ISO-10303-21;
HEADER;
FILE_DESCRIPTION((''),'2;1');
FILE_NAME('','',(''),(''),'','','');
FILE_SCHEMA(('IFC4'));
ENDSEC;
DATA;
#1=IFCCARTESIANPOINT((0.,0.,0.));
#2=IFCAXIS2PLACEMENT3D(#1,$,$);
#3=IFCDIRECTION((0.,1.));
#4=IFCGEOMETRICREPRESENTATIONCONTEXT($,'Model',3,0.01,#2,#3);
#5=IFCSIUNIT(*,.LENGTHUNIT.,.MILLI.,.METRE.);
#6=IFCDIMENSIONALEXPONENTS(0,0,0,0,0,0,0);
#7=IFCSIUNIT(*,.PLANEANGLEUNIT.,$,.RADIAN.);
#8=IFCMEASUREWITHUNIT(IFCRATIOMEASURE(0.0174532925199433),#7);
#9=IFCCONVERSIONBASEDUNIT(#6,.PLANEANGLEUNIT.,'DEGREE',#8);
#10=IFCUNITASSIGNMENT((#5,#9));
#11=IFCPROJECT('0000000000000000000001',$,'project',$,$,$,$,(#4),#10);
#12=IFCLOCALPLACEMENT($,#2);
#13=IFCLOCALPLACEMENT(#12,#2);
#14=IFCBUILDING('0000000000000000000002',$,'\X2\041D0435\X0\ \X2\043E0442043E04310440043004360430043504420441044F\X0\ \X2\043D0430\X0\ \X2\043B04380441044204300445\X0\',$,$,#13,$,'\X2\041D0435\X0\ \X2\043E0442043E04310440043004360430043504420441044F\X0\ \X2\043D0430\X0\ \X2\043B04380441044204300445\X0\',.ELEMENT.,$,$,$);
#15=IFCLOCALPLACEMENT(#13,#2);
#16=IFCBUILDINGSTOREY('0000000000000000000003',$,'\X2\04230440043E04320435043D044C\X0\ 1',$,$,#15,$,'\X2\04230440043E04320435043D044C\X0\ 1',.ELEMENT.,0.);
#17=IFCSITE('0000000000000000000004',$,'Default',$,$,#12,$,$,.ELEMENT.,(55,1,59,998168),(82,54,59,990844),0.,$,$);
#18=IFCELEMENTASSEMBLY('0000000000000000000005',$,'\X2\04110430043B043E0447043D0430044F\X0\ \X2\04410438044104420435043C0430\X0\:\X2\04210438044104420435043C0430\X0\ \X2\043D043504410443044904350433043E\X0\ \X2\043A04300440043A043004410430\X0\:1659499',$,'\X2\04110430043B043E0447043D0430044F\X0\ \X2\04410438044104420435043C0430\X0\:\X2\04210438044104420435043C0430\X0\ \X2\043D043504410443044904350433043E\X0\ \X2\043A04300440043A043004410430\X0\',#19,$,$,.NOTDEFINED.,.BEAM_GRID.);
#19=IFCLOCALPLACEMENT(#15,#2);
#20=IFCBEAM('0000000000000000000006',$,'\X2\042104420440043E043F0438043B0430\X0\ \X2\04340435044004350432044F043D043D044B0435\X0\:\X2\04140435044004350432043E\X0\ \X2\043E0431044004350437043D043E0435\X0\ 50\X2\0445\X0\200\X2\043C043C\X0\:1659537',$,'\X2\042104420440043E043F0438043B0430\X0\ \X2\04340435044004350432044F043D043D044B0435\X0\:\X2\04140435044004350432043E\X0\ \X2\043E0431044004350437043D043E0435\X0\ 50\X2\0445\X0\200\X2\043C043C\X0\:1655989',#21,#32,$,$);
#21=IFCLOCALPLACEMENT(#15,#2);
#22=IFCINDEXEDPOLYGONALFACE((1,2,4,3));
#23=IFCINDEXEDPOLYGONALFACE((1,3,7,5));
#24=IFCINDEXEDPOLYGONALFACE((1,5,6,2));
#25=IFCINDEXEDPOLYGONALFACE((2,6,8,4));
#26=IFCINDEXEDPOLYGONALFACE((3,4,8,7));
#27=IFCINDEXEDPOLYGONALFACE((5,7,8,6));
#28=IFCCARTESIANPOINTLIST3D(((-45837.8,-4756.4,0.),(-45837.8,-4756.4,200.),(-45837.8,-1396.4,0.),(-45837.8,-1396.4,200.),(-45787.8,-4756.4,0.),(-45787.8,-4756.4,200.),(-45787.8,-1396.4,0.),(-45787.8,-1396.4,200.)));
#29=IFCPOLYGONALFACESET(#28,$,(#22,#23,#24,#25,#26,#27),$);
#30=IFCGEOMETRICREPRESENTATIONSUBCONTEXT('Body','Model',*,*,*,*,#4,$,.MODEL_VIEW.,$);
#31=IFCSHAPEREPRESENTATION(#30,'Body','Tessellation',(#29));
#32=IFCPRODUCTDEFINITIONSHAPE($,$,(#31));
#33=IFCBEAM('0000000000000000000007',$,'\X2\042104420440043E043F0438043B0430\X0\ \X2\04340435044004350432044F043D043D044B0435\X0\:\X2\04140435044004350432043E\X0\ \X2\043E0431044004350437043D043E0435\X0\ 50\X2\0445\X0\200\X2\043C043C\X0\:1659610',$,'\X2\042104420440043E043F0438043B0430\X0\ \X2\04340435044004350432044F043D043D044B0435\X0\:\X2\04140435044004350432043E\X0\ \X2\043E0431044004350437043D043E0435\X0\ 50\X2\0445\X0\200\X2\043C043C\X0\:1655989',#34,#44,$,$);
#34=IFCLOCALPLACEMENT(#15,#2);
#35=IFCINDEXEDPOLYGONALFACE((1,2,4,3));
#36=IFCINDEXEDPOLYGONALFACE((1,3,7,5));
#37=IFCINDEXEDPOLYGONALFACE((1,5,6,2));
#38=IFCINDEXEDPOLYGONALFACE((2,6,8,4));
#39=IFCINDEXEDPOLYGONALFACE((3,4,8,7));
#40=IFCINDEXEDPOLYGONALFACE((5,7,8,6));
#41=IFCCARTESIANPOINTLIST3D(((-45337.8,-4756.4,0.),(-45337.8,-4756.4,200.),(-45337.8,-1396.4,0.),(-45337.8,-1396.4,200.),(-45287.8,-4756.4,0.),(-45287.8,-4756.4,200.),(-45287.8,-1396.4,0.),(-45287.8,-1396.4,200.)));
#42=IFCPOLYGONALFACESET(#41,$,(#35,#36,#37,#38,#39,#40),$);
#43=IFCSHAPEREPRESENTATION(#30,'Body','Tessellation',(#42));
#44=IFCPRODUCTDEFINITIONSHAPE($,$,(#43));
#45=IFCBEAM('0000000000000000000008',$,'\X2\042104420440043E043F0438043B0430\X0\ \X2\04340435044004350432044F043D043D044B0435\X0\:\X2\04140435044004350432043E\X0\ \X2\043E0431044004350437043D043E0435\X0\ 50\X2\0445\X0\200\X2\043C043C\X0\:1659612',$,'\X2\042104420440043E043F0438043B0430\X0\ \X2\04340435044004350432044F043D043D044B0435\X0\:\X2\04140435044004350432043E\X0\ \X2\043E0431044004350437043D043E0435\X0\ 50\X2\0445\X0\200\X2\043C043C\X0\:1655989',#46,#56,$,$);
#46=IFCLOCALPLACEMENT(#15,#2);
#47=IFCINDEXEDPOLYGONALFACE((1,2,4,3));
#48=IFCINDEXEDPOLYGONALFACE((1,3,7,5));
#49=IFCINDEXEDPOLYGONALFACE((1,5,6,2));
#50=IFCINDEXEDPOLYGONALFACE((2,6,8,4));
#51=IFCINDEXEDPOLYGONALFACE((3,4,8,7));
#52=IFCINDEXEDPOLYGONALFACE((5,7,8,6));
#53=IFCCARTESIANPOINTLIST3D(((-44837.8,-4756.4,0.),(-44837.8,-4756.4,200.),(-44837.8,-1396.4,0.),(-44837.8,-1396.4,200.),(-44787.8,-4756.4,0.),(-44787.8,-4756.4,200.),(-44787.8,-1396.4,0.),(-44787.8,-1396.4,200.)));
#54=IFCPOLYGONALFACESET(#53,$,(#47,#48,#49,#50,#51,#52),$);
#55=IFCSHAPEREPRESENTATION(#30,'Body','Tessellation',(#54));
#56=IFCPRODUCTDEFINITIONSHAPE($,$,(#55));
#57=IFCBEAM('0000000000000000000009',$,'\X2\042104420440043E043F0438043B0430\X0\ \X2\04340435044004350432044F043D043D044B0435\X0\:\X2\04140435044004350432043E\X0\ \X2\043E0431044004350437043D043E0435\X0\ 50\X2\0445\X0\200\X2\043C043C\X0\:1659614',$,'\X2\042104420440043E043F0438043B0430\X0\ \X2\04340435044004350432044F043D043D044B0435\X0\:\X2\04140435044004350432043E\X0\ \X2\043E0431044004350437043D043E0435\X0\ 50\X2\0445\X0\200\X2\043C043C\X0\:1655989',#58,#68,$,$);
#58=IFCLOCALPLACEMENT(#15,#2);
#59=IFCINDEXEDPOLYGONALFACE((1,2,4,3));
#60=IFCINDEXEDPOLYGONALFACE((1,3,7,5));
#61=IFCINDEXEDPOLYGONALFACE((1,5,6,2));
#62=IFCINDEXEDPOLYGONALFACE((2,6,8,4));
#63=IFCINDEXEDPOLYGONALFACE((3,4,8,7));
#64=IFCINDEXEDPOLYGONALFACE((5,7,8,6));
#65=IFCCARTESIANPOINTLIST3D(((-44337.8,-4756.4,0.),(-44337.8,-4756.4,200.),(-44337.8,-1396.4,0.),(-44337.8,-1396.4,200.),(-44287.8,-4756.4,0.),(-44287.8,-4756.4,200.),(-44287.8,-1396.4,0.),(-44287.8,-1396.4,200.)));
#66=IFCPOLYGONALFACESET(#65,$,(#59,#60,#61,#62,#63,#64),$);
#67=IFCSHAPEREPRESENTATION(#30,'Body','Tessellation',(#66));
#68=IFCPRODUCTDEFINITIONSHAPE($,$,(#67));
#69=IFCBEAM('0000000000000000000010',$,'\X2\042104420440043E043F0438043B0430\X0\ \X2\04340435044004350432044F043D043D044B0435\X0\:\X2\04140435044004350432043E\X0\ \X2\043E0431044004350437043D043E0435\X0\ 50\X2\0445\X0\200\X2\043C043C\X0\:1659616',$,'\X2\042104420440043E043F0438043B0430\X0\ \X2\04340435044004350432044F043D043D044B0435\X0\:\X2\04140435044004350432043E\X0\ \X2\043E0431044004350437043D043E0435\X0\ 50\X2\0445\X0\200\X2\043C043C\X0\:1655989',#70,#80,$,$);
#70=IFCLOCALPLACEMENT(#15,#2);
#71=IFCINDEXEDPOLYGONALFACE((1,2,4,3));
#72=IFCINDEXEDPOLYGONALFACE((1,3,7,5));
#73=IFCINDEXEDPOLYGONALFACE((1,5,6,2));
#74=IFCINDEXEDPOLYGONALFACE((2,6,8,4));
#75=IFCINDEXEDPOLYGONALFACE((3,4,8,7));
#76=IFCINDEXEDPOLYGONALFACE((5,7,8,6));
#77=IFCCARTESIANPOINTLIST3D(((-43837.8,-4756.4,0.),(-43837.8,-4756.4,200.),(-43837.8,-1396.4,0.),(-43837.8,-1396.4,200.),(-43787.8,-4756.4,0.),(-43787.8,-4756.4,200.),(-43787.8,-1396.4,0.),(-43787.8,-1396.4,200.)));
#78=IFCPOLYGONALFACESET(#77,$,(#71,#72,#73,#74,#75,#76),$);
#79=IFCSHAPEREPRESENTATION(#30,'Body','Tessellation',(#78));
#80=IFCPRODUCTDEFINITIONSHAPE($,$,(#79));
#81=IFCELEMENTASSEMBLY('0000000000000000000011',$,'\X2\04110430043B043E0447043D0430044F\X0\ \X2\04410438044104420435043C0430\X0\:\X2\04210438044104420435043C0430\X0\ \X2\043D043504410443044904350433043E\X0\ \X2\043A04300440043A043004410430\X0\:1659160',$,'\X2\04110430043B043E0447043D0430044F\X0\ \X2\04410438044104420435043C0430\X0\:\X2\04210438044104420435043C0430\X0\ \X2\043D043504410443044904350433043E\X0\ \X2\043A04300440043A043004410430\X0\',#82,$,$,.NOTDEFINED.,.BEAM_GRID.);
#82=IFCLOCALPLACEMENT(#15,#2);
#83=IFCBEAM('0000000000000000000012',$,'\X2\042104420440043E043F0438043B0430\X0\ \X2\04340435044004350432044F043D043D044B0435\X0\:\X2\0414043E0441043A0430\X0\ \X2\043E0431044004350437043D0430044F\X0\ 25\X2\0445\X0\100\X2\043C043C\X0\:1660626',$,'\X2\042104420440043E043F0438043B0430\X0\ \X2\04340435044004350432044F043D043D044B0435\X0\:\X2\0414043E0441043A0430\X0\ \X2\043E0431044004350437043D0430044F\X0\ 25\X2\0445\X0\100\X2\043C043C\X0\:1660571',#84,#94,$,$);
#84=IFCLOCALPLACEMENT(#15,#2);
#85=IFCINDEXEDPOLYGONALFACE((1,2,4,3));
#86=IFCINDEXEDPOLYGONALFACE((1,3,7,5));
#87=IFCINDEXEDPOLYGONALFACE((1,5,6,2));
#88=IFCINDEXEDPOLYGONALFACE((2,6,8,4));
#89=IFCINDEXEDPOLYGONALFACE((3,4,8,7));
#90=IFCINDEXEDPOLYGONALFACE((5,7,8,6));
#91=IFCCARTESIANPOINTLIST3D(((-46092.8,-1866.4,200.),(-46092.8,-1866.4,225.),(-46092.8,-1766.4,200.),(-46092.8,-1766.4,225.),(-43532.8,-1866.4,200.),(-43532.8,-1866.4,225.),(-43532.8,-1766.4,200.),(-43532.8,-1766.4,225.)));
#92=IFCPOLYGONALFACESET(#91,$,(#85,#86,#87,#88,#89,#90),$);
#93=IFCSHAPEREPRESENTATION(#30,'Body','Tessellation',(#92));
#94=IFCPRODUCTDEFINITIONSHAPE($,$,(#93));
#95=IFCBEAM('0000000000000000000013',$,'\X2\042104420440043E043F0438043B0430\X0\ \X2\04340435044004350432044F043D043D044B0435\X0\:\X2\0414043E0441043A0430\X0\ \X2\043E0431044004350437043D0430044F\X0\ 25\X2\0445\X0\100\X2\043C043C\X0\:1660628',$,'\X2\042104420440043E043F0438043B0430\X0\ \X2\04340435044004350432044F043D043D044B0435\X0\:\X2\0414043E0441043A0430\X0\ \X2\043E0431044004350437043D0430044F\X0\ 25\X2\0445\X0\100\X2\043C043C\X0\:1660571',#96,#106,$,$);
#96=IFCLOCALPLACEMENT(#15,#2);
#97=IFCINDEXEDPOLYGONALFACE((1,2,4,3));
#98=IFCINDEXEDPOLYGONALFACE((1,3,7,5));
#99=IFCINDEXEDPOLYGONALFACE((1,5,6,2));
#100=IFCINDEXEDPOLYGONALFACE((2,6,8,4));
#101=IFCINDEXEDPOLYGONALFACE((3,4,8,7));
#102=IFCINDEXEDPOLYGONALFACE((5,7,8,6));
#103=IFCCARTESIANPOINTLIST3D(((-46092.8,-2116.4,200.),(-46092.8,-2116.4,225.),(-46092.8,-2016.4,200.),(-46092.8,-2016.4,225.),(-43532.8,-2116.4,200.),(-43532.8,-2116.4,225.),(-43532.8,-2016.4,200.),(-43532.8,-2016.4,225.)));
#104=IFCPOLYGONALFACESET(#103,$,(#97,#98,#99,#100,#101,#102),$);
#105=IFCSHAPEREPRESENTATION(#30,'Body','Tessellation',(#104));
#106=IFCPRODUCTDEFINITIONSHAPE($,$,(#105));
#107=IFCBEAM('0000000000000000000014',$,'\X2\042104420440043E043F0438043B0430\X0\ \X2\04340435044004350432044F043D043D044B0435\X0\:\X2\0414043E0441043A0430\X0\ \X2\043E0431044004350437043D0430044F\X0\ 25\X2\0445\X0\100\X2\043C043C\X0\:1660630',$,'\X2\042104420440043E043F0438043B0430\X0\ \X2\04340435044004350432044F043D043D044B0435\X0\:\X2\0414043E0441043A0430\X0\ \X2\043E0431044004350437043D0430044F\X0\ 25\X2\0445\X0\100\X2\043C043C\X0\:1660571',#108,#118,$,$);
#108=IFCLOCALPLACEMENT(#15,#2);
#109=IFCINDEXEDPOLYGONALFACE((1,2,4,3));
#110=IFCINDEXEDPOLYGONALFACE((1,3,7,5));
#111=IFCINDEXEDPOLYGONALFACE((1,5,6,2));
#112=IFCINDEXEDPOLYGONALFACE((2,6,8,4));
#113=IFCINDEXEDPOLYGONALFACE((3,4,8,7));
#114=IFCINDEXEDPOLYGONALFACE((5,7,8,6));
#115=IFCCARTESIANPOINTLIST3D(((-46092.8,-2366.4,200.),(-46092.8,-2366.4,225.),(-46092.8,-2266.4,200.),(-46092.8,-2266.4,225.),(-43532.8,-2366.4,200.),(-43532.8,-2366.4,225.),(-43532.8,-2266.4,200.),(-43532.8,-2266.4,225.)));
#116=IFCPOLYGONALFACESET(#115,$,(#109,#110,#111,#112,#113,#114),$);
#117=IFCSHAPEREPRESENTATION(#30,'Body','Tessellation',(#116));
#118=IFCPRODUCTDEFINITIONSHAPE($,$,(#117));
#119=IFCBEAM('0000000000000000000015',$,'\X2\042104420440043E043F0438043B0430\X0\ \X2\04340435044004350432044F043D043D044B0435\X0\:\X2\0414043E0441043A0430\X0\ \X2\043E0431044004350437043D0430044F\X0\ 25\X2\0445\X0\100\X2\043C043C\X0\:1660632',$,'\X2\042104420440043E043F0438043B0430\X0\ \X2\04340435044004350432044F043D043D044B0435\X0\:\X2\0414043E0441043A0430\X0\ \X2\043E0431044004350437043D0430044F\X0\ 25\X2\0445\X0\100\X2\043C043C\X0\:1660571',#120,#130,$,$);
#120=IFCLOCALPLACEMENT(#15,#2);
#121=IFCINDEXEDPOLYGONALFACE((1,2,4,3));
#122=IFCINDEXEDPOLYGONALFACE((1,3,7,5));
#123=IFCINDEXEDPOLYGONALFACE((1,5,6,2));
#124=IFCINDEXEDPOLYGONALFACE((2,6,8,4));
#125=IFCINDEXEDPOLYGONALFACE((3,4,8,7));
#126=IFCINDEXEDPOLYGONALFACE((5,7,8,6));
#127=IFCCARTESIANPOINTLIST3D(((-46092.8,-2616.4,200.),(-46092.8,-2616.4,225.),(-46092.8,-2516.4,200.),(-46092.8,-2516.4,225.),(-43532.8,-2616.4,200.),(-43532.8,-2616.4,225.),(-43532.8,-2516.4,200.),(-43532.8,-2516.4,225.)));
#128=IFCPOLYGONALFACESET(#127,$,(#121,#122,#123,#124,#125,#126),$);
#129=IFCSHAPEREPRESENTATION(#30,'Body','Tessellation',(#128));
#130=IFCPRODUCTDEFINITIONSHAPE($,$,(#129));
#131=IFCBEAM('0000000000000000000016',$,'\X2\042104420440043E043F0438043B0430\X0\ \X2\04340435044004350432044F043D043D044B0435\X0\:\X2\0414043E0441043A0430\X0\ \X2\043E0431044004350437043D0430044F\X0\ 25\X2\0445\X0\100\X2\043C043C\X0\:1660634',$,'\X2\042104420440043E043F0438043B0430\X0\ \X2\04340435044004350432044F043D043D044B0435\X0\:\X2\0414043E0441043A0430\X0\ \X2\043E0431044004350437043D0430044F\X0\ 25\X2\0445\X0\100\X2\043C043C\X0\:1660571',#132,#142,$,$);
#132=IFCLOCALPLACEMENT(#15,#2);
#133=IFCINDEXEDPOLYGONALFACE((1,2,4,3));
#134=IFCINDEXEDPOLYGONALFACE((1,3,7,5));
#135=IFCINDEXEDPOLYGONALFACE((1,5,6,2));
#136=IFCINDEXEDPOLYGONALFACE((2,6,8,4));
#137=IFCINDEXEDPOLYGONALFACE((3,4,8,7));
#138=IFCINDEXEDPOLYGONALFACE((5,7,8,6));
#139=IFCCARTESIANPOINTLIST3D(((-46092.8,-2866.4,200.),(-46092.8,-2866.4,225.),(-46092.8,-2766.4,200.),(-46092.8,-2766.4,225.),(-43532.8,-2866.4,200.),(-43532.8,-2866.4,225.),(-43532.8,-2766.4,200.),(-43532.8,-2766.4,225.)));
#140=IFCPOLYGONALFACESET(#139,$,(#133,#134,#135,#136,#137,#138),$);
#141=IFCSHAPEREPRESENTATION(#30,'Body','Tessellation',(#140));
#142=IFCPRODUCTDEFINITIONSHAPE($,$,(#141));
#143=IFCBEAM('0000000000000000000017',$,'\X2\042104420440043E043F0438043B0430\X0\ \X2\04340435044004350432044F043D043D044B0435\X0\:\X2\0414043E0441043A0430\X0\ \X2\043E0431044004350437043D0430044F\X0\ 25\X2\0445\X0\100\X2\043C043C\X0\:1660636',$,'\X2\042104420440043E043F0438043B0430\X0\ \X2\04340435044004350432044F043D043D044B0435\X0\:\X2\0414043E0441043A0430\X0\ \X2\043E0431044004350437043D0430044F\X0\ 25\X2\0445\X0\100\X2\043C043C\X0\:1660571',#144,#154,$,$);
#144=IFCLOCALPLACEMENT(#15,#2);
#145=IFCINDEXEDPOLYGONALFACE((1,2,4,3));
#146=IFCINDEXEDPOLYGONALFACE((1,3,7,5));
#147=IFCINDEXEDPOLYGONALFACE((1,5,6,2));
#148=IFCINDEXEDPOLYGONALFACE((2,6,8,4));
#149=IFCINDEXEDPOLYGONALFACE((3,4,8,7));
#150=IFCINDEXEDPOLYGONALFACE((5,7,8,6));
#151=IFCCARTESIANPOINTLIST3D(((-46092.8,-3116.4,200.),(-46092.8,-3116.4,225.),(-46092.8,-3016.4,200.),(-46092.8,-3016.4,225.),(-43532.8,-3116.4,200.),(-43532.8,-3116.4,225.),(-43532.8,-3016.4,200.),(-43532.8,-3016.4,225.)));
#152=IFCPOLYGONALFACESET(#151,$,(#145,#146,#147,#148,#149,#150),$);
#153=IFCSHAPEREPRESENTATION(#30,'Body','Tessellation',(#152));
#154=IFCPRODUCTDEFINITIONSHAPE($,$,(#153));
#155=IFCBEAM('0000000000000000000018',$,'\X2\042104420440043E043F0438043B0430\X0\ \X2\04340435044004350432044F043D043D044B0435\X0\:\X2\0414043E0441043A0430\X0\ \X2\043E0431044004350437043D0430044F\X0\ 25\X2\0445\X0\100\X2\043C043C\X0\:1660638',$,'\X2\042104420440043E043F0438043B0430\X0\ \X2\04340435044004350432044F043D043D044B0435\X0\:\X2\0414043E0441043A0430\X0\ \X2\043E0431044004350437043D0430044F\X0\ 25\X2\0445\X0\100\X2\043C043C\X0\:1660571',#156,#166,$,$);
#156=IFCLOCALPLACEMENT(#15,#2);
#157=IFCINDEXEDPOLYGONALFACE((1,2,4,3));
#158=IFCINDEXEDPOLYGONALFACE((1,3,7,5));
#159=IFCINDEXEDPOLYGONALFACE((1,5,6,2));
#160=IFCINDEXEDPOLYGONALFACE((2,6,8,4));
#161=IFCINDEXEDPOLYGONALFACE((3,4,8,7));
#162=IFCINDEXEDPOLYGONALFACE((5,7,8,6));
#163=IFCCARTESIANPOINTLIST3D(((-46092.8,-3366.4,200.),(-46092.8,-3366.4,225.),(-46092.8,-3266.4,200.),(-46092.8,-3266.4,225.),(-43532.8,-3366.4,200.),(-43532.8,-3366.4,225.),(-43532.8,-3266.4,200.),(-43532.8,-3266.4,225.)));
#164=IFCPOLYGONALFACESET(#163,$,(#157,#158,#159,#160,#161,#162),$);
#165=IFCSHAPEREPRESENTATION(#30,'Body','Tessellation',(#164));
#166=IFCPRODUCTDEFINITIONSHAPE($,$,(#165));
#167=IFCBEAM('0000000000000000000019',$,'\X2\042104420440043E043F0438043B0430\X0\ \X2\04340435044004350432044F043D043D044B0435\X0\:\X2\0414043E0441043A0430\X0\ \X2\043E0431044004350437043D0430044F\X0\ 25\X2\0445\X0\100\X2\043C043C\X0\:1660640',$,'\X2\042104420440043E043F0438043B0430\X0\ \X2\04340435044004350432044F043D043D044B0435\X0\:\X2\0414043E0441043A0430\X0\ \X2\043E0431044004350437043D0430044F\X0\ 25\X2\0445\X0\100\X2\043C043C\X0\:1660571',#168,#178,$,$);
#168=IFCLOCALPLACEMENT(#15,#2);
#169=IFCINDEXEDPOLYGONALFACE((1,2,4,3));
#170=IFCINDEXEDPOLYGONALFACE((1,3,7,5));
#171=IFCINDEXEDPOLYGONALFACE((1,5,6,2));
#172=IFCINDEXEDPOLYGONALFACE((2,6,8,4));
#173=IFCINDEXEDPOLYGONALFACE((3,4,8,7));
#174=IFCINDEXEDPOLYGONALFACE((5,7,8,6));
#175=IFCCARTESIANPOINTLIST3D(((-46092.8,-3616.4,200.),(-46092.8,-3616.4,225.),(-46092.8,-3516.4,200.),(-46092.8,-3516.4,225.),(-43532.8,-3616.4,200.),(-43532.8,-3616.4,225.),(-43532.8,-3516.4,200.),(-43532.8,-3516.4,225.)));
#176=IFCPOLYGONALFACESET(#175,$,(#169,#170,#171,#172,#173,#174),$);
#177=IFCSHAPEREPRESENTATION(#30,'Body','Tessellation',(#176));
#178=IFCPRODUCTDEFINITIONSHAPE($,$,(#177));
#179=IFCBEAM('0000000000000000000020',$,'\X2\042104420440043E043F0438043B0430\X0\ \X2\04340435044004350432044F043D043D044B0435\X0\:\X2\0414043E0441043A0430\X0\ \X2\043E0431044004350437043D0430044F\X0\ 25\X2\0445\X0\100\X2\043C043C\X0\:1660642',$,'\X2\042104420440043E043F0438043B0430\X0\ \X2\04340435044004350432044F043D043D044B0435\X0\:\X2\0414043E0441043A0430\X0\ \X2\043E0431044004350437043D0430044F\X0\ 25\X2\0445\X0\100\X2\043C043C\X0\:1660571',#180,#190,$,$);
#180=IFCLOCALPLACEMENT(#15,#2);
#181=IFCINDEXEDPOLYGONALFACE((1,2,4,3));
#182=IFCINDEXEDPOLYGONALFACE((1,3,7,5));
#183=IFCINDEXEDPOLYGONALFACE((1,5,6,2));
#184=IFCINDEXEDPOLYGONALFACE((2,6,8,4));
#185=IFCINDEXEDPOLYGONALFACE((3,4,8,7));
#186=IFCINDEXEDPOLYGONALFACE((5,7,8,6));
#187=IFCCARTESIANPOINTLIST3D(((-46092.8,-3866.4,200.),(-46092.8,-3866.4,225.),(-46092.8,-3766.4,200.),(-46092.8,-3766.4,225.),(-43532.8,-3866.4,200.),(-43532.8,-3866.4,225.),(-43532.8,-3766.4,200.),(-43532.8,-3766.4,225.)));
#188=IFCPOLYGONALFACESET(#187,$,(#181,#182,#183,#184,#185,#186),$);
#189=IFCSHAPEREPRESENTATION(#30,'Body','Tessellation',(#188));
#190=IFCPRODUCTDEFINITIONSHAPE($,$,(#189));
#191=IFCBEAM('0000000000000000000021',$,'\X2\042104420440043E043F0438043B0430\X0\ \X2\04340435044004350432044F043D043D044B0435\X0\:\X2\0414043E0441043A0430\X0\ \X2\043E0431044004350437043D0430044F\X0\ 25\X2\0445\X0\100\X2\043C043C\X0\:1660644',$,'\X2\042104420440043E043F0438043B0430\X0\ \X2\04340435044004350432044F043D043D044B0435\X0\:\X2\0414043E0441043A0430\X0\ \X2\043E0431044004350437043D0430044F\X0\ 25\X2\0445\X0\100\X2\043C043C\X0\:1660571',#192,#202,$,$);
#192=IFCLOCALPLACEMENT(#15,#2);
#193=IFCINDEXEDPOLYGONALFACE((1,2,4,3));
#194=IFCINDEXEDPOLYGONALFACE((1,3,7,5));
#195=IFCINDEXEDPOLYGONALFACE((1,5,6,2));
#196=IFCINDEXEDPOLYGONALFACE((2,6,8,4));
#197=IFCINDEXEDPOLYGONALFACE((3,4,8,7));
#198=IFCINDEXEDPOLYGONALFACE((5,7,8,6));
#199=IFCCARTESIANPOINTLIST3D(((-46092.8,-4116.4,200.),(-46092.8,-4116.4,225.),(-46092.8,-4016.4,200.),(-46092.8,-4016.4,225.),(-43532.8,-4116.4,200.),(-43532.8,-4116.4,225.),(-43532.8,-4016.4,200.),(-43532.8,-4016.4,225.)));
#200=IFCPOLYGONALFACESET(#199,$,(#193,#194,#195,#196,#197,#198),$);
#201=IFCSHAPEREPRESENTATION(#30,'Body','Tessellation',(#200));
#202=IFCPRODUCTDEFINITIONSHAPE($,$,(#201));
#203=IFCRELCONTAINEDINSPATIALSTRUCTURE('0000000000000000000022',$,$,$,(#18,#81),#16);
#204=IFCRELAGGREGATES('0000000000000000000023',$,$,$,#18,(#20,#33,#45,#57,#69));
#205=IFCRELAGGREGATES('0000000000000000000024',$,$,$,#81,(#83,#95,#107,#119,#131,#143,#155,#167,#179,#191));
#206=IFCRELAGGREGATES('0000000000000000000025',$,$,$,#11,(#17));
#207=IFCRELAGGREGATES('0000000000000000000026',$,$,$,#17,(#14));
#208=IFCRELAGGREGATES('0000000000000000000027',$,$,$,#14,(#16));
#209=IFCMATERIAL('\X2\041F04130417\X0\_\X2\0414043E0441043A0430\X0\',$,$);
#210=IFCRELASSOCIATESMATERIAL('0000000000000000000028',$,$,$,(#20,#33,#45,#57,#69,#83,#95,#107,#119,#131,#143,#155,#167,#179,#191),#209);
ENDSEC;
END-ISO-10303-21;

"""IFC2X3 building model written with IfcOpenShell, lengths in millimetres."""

from ifc_helpers import new_model, entity, si_unit, converted_unit, direction, frame, frame_2d, origin, origin_2d_with_axis, place, context, subcontext, project, spatial, rectangle, extrude, material, element, aggregate, save


model = new_model("IFC2X3")

# Units and contexts
model_context = context("Model", 3, precision=0.01, world=origin(), true_north=direction((0.0, 1.0)))
body_context = subcontext(model_context, "Body", "Model", "MODEL_VIEW")
ifc_project = project(units=[si_unit("LENGTHUNIT", "METRE", prefix="MILLI"), converted_unit("PLANEANGLEUNIT", "DEGREE", entity("IfcRatioMeasure", 0.0174532925199433), si_unit("PLANEANGLEUNIT", "RADIAN"), dimensions=[0, 0, 0, 0, 0, 0, 0])], contexts=[model_context])

# Site, building, storey
site_placement = place(None, origin())
site = spatial("IfcSite", under=ifc_project, at=site_placement, Name="Default", CompositionType="ELEMENT", RefLatitude=(55, 1, 59, 998168), RefLongitude=(82, 54, 59, 990844), RefElevation=0.0)
building_placement = place(site_placement, origin())
building = spatial("IfcBuilding", under=site, at=building_placement, Name="Не отображается на листах", LongName="Не отображается на листах", CompositionType="ELEMENT")
storey_placement = place(building_placement, frame((0.0, 0.0, 0.0)))
storey = spatial("IfcBuildingStorey", under=building, at=storey_placement, Name="Уровень 1", LongName="Уровень 1", CompositionType="ELEMENT", Elevation=0.0)

# Element assemblies, beams
assembly_1_placement = place(storey_placement, origin())
assembly_1 = element("IfcElementAssembly", 1, at=assembly_1_placement, inside=storey, Name="Балочная система:Система несущего каркаса:1659499", ObjectType="Балочная система:Система несущего каркаса", AssemblyPlace="NOTDEFINED", PredefinedType="BEAM_GRID")
ifc_material_1 = material(Name="ПГЗ_Доска")
beam_1_placement = place(assembly_1_placement, frame((-45812.8, -4756.4, 0.0), z_axis=(0.0, 0.0, 1.0), x_axis=(0.0, 1.0, 0.0)))
beam_1 = element("IfcBeam", 2, at=beam_1_placement, material=ifc_material_1, Name="Стропила деревянные:Дерево обрезное 50х200мм:1659537", ObjectType="Стропила деревянные:Дерево обрезное 50х200мм:1655989", context=body_context, shape_type="SweptSolid", body=[
    extrude(rectangle(XDim=200.0, YDim=50.0, at=frame_2d((0.0, 0.0), x_axis=(1.0, 0.0))), frame((0.0, 0.0, 100.0), z_axis=(1.0, 0.0, 0.0), x_axis=(0.0, 0.0, -1.0)), (0.0, 0.0, 1.0), 3360.0),
])
beam_2_placement = place(assembly_1_placement, frame((-45312.8, -4756.4, 0.0), z_axis=(0.0, 0.0, 1.0), x_axis=(0.0, 1.0, 0.0)))
beam_2 = element("IfcBeam", 3, at=beam_2_placement, material=ifc_material_1, Name="Стропила деревянные:Дерево обрезное 50х200мм:1659610", ObjectType="Стропила деревянные:Дерево обрезное 50х200мм:1655989", context=body_context, shape_type="SweptSolid", body=[
    extrude(rectangle(XDim=200.0, YDim=50.0, at=frame_2d((0.0, 0.0), x_axis=(1.0, 0.0))), frame((0.0, 0.0, 100.0), z_axis=(1.0, 0.0, 0.0), x_axis=(0.0, 0.0, -1.0)), (0.0, 0.0, 1.0), 3360.0),
])
beam_3_placement = place(assembly_1_placement, frame((-44812.8, -4756.4, 0.0), z_axis=(0.0, 0.0, 1.0), x_axis=(0.0, 1.0, 0.0)))
beam_3 = element("IfcBeam", 4, at=beam_3_placement, material=ifc_material_1, Name="Стропила деревянные:Дерево обрезное 50х200мм:1659612", ObjectType="Стропила деревянные:Дерево обрезное 50х200мм:1655989", context=body_context, shape_type="SweptSolid", body=[
    extrude(rectangle(XDim=200.0, YDim=50.0, at=frame_2d((0.0, 0.0), x_axis=(1.0, 0.0))), frame((0.0, 0.0, 100.0), z_axis=(1.0, 0.0, 0.0), x_axis=(0.0, 0.0, -1.0)), (0.0, 0.0, 1.0), 3360.0),
])
beam_4_placement = place(assembly_1_placement, frame((-44312.8, -4756.4, 0.0), z_axis=(0.0, 0.0, 1.0), x_axis=(0.0, 1.0, 0.0)))
beam_4 = element("IfcBeam", 5, at=beam_4_placement, material=ifc_material_1, Name="Стропила деревянные:Дерево обрезное 50х200мм:1659614", ObjectType="Стропила деревянные:Дерево обрезное 50х200мм:1655989", context=body_context, shape_type="SweptSolid", body=[
    extrude(rectangle(XDim=200.0, YDim=50.0, at=frame_2d((0.0, 0.0), x_axis=(1.0, 0.0))), frame((0.0, 0.0, 100.0), z_axis=(1.0, 0.0, 0.0), x_axis=(0.0, 0.0, -1.0)), (0.0, 0.0, 1.0), 3360.0),
])
beam_5_placement = place(assembly_1_placement, frame((-43812.8, -4756.4, 0.0), z_axis=(0.0, 0.0, 1.0), x_axis=(0.0, 1.0, 0.0)))
beam_5 = element("IfcBeam", 6, at=beam_5_placement, material=ifc_material_1, Name="Стропила деревянные:Дерево обрезное 50х200мм:1659616", ObjectType="Стропила деревянные:Дерево обрезное 50х200мм:1655989", context=body_context, shape_type="SweptSolid", body=[
    extrude(rectangle(XDim=200.0, YDim=50.0, at=frame_2d((0.0, 0.0), x_axis=(1.0, 0.0))), frame((0.0, 0.0, 100.0), z_axis=(1.0, 0.0, 0.0), x_axis=(0.0, 0.0, -1.0)), (0.0, 0.0, 1.0), 3360.0),
])
aggregate(assembly_1, [beam_1, beam_2, beam_3, beam_4, beam_5])
assembly_2_placement = place(storey_placement, origin())
assembly_2 = element("IfcElementAssembly", 7, at=assembly_2_placement, inside=storey, Name="Балочная система:Система несущего каркаса:1659160", ObjectType="Балочная система:Система несущего каркаса", AssemblyPlace="NOTDEFINED", PredefinedType="BEAM_GRID")
beam_6_placement = place(assembly_2_placement, frame((-46092.8, -1816.4, 0.0)))
beam_6 = element("IfcBeam", 8, at=beam_6_placement, material=ifc_material_1, Name="Стропила деревянные:Доска обрезная 25х100мм:1660626", ObjectType="Стропила деревянные:Доска обрезная 25х100мм:1660571", context=body_context, shape_type="SweptSolid", body=[
    extrude(rectangle(XDim=25.0, YDim=100.0, at=origin_2d_with_axis()), frame((0.0, 0.0, 212.5), z_axis=(1.0, 0.0, 0.0), x_axis=(0.0, 0.0, -1.0)), (0.0, 0.0, 1.0), 2560.0),
])
beam_7_placement = place(assembly_2_placement, frame((-46092.8, -2066.4, 0.0)))
beam_7 = element("IfcBeam", 9, at=beam_7_placement, material=ifc_material_1, Name="Стропила деревянные:Доска обрезная 25х100мм:1660628", ObjectType="Стропила деревянные:Доска обрезная 25х100мм:1660571", context=body_context, shape_type="SweptSolid", body=[
    extrude(rectangle(XDim=25.0, YDim=100.0, at=origin_2d_with_axis()), frame((0.0, 0.0, 212.5), z_axis=(1.0, 0.0, 0.0), x_axis=(0.0, 0.0, -1.0)), (0.0, 0.0, 1.0), 2560.0),
])
beam_8_placement = place(assembly_2_placement, frame((-46092.8, -2316.4, 0.0)))
beam_8 = element("IfcBeam", 10, at=beam_8_placement, material=ifc_material_1, Name="Стропила деревянные:Доска обрезная 25х100мм:1660630", ObjectType="Стропила деревянные:Доска обрезная 25х100мм:1660571", context=body_context, shape_type="SweptSolid", body=[
    extrude(rectangle(XDim=25.0, YDim=100.0, at=origin_2d_with_axis()), frame((0.0, 0.0, 212.5), z_axis=(1.0, 0.0, 0.0), x_axis=(0.0, 0.0, -1.0)), (0.0, 0.0, 1.0), 2560.0),
])
beam_9_placement = place(assembly_2_placement, frame((-46092.8, -2566.4, 0.0)))
beam_9 = element("IfcBeam", 11, at=beam_9_placement, material=ifc_material_1, Name="Стропила деревянные:Доска обрезная 25х100мм:1660632", ObjectType="Стропила деревянные:Доска обрезная 25х100мм:1660571", context=body_context, shape_type="SweptSolid", body=[
    extrude(rectangle(XDim=25.0, YDim=100.0, at=origin_2d_with_axis()), frame((0.0, 0.0, 212.5), z_axis=(1.0, 0.0, 0.0), x_axis=(0.0, 0.0, -1.0)), (0.0, 0.0, 1.0), 2560.0),
])
beam_10_placement = place(assembly_2_placement, frame((-46092.8, -2816.4, 0.0)))
beam_10 = element("IfcBeam", 12, at=beam_10_placement, material=ifc_material_1, Name="Стропила деревянные:Доска обрезная 25х100мм:1660634", ObjectType="Стропила деревянные:Доска обрезная 25х100мм:1660571", context=body_context, shape_type="SweptSolid", body=[
    extrude(rectangle(XDim=25.0, YDim=100.0, at=origin_2d_with_axis()), frame((0.0, 0.0, 212.5), z_axis=(1.0, 0.0, 0.0), x_axis=(0.0, 0.0, -1.0)), (0.0, 0.0, 1.0), 2560.0),
])
beam_11_placement = place(assembly_2_placement, frame((-46092.8, -3066.4, 0.0)))
beam_11 = element("IfcBeam", 13, at=beam_11_placement, material=ifc_material_1, Name="Стропила деревянные:Доска обрезная 25х100мм:1660636", ObjectType="Стропила деревянные:Доска обрезная 25х100мм:1660571", context=body_context, shape_type="SweptSolid", body=[
    extrude(rectangle(XDim=25.0, YDim=100.0, at=origin_2d_with_axis()), frame((0.0, 0.0, 212.5), z_axis=(1.0, 0.0, 0.0), x_axis=(0.0, 0.0, -1.0)), (0.0, 0.0, 1.0), 2560.0),
])
beam_12_placement = place(assembly_2_placement, frame((-46092.8, -3316.4, 0.0)))
beam_12 = element("IfcBeam", 14, at=beam_12_placement, material=ifc_material_1, Name="Стропила деревянные:Доска обрезная 25х100мм:1660638", ObjectType="Стропила деревянные:Доска обрезная 25х100мм:1660571", context=body_context, shape_type="SweptSolid", body=[
    extrude(rectangle(XDim=25.0, YDim=100.0, at=origin_2d_with_axis()), frame((0.0, 0.0, 212.5), z_axis=(1.0, 0.0, 0.0), x_axis=(0.0, 0.0, -1.0)), (0.0, 0.0, 1.0), 2560.0),
])
beam_13_placement = place(assembly_2_placement, frame((-46092.8, -3566.4, 0.0)))
beam_13 = element("IfcBeam", 15, at=beam_13_placement, material=ifc_material_1, Name="Стропила деревянные:Доска обрезная 25х100мм:1660640", ObjectType="Стропила деревянные:Доска обрезная 25х100мм:1660571", context=body_context, shape_type="SweptSolid", body=[
    extrude(rectangle(XDim=25.0, YDim=100.0, at=origin_2d_with_axis()), frame((0.0, 0.0, 212.5), z_axis=(1.0, 0.0, 0.0), x_axis=(0.0, 0.0, -1.0)), (0.0, 0.0, 1.0), 2560.0),
])
beam_14_placement = place(assembly_2_placement, frame((-46092.8, -3816.4, 0.0)))
beam_14 = element("IfcBeam", 16, at=beam_14_placement, material=ifc_material_1, Name="Стропила деревянные:Доска обрезная 25х100мм:1660642", ObjectType="Стропила деревянные:Доска обрезная 25х100мм:1660571", context=body_context, shape_type="SweptSolid", body=[
    extrude(rectangle(XDim=25.0, YDim=100.0, at=origin_2d_with_axis()), frame((0.0, 0.0, 212.5), z_axis=(1.0, 0.0, 0.0), x_axis=(0.0, 0.0, -1.0)), (0.0, 0.0, 1.0), 2560.0),
])
beam_15_placement = place(assembly_2_placement, frame((-46092.8, -4066.4, 0.0)))
beam_15 = element("IfcBeam", 17, at=beam_15_placement, material=ifc_material_1, Name="Стропила деревянные:Доска обрезная 25х100мм:1660644", ObjectType="Стропила деревянные:Доска обрезная 25х100мм:1660571", context=body_context, shape_type="SweptSolid", body=[
    extrude(rectangle(XDim=25.0, YDim=100.0, at=origin_2d_with_axis()), frame((0.0, 0.0, 212.5), z_axis=(1.0, 0.0, 0.0), x_axis=(0.0, 0.0, -1.0)), (0.0, 0.0, 1.0), 2560.0),
])
aggregate(assembly_2, [beam_6, beam_7, beam_8, beam_9, beam_10, beam_11, beam_12, beam_13, beam_14, beam_15])

save(model, "model.ifc")
